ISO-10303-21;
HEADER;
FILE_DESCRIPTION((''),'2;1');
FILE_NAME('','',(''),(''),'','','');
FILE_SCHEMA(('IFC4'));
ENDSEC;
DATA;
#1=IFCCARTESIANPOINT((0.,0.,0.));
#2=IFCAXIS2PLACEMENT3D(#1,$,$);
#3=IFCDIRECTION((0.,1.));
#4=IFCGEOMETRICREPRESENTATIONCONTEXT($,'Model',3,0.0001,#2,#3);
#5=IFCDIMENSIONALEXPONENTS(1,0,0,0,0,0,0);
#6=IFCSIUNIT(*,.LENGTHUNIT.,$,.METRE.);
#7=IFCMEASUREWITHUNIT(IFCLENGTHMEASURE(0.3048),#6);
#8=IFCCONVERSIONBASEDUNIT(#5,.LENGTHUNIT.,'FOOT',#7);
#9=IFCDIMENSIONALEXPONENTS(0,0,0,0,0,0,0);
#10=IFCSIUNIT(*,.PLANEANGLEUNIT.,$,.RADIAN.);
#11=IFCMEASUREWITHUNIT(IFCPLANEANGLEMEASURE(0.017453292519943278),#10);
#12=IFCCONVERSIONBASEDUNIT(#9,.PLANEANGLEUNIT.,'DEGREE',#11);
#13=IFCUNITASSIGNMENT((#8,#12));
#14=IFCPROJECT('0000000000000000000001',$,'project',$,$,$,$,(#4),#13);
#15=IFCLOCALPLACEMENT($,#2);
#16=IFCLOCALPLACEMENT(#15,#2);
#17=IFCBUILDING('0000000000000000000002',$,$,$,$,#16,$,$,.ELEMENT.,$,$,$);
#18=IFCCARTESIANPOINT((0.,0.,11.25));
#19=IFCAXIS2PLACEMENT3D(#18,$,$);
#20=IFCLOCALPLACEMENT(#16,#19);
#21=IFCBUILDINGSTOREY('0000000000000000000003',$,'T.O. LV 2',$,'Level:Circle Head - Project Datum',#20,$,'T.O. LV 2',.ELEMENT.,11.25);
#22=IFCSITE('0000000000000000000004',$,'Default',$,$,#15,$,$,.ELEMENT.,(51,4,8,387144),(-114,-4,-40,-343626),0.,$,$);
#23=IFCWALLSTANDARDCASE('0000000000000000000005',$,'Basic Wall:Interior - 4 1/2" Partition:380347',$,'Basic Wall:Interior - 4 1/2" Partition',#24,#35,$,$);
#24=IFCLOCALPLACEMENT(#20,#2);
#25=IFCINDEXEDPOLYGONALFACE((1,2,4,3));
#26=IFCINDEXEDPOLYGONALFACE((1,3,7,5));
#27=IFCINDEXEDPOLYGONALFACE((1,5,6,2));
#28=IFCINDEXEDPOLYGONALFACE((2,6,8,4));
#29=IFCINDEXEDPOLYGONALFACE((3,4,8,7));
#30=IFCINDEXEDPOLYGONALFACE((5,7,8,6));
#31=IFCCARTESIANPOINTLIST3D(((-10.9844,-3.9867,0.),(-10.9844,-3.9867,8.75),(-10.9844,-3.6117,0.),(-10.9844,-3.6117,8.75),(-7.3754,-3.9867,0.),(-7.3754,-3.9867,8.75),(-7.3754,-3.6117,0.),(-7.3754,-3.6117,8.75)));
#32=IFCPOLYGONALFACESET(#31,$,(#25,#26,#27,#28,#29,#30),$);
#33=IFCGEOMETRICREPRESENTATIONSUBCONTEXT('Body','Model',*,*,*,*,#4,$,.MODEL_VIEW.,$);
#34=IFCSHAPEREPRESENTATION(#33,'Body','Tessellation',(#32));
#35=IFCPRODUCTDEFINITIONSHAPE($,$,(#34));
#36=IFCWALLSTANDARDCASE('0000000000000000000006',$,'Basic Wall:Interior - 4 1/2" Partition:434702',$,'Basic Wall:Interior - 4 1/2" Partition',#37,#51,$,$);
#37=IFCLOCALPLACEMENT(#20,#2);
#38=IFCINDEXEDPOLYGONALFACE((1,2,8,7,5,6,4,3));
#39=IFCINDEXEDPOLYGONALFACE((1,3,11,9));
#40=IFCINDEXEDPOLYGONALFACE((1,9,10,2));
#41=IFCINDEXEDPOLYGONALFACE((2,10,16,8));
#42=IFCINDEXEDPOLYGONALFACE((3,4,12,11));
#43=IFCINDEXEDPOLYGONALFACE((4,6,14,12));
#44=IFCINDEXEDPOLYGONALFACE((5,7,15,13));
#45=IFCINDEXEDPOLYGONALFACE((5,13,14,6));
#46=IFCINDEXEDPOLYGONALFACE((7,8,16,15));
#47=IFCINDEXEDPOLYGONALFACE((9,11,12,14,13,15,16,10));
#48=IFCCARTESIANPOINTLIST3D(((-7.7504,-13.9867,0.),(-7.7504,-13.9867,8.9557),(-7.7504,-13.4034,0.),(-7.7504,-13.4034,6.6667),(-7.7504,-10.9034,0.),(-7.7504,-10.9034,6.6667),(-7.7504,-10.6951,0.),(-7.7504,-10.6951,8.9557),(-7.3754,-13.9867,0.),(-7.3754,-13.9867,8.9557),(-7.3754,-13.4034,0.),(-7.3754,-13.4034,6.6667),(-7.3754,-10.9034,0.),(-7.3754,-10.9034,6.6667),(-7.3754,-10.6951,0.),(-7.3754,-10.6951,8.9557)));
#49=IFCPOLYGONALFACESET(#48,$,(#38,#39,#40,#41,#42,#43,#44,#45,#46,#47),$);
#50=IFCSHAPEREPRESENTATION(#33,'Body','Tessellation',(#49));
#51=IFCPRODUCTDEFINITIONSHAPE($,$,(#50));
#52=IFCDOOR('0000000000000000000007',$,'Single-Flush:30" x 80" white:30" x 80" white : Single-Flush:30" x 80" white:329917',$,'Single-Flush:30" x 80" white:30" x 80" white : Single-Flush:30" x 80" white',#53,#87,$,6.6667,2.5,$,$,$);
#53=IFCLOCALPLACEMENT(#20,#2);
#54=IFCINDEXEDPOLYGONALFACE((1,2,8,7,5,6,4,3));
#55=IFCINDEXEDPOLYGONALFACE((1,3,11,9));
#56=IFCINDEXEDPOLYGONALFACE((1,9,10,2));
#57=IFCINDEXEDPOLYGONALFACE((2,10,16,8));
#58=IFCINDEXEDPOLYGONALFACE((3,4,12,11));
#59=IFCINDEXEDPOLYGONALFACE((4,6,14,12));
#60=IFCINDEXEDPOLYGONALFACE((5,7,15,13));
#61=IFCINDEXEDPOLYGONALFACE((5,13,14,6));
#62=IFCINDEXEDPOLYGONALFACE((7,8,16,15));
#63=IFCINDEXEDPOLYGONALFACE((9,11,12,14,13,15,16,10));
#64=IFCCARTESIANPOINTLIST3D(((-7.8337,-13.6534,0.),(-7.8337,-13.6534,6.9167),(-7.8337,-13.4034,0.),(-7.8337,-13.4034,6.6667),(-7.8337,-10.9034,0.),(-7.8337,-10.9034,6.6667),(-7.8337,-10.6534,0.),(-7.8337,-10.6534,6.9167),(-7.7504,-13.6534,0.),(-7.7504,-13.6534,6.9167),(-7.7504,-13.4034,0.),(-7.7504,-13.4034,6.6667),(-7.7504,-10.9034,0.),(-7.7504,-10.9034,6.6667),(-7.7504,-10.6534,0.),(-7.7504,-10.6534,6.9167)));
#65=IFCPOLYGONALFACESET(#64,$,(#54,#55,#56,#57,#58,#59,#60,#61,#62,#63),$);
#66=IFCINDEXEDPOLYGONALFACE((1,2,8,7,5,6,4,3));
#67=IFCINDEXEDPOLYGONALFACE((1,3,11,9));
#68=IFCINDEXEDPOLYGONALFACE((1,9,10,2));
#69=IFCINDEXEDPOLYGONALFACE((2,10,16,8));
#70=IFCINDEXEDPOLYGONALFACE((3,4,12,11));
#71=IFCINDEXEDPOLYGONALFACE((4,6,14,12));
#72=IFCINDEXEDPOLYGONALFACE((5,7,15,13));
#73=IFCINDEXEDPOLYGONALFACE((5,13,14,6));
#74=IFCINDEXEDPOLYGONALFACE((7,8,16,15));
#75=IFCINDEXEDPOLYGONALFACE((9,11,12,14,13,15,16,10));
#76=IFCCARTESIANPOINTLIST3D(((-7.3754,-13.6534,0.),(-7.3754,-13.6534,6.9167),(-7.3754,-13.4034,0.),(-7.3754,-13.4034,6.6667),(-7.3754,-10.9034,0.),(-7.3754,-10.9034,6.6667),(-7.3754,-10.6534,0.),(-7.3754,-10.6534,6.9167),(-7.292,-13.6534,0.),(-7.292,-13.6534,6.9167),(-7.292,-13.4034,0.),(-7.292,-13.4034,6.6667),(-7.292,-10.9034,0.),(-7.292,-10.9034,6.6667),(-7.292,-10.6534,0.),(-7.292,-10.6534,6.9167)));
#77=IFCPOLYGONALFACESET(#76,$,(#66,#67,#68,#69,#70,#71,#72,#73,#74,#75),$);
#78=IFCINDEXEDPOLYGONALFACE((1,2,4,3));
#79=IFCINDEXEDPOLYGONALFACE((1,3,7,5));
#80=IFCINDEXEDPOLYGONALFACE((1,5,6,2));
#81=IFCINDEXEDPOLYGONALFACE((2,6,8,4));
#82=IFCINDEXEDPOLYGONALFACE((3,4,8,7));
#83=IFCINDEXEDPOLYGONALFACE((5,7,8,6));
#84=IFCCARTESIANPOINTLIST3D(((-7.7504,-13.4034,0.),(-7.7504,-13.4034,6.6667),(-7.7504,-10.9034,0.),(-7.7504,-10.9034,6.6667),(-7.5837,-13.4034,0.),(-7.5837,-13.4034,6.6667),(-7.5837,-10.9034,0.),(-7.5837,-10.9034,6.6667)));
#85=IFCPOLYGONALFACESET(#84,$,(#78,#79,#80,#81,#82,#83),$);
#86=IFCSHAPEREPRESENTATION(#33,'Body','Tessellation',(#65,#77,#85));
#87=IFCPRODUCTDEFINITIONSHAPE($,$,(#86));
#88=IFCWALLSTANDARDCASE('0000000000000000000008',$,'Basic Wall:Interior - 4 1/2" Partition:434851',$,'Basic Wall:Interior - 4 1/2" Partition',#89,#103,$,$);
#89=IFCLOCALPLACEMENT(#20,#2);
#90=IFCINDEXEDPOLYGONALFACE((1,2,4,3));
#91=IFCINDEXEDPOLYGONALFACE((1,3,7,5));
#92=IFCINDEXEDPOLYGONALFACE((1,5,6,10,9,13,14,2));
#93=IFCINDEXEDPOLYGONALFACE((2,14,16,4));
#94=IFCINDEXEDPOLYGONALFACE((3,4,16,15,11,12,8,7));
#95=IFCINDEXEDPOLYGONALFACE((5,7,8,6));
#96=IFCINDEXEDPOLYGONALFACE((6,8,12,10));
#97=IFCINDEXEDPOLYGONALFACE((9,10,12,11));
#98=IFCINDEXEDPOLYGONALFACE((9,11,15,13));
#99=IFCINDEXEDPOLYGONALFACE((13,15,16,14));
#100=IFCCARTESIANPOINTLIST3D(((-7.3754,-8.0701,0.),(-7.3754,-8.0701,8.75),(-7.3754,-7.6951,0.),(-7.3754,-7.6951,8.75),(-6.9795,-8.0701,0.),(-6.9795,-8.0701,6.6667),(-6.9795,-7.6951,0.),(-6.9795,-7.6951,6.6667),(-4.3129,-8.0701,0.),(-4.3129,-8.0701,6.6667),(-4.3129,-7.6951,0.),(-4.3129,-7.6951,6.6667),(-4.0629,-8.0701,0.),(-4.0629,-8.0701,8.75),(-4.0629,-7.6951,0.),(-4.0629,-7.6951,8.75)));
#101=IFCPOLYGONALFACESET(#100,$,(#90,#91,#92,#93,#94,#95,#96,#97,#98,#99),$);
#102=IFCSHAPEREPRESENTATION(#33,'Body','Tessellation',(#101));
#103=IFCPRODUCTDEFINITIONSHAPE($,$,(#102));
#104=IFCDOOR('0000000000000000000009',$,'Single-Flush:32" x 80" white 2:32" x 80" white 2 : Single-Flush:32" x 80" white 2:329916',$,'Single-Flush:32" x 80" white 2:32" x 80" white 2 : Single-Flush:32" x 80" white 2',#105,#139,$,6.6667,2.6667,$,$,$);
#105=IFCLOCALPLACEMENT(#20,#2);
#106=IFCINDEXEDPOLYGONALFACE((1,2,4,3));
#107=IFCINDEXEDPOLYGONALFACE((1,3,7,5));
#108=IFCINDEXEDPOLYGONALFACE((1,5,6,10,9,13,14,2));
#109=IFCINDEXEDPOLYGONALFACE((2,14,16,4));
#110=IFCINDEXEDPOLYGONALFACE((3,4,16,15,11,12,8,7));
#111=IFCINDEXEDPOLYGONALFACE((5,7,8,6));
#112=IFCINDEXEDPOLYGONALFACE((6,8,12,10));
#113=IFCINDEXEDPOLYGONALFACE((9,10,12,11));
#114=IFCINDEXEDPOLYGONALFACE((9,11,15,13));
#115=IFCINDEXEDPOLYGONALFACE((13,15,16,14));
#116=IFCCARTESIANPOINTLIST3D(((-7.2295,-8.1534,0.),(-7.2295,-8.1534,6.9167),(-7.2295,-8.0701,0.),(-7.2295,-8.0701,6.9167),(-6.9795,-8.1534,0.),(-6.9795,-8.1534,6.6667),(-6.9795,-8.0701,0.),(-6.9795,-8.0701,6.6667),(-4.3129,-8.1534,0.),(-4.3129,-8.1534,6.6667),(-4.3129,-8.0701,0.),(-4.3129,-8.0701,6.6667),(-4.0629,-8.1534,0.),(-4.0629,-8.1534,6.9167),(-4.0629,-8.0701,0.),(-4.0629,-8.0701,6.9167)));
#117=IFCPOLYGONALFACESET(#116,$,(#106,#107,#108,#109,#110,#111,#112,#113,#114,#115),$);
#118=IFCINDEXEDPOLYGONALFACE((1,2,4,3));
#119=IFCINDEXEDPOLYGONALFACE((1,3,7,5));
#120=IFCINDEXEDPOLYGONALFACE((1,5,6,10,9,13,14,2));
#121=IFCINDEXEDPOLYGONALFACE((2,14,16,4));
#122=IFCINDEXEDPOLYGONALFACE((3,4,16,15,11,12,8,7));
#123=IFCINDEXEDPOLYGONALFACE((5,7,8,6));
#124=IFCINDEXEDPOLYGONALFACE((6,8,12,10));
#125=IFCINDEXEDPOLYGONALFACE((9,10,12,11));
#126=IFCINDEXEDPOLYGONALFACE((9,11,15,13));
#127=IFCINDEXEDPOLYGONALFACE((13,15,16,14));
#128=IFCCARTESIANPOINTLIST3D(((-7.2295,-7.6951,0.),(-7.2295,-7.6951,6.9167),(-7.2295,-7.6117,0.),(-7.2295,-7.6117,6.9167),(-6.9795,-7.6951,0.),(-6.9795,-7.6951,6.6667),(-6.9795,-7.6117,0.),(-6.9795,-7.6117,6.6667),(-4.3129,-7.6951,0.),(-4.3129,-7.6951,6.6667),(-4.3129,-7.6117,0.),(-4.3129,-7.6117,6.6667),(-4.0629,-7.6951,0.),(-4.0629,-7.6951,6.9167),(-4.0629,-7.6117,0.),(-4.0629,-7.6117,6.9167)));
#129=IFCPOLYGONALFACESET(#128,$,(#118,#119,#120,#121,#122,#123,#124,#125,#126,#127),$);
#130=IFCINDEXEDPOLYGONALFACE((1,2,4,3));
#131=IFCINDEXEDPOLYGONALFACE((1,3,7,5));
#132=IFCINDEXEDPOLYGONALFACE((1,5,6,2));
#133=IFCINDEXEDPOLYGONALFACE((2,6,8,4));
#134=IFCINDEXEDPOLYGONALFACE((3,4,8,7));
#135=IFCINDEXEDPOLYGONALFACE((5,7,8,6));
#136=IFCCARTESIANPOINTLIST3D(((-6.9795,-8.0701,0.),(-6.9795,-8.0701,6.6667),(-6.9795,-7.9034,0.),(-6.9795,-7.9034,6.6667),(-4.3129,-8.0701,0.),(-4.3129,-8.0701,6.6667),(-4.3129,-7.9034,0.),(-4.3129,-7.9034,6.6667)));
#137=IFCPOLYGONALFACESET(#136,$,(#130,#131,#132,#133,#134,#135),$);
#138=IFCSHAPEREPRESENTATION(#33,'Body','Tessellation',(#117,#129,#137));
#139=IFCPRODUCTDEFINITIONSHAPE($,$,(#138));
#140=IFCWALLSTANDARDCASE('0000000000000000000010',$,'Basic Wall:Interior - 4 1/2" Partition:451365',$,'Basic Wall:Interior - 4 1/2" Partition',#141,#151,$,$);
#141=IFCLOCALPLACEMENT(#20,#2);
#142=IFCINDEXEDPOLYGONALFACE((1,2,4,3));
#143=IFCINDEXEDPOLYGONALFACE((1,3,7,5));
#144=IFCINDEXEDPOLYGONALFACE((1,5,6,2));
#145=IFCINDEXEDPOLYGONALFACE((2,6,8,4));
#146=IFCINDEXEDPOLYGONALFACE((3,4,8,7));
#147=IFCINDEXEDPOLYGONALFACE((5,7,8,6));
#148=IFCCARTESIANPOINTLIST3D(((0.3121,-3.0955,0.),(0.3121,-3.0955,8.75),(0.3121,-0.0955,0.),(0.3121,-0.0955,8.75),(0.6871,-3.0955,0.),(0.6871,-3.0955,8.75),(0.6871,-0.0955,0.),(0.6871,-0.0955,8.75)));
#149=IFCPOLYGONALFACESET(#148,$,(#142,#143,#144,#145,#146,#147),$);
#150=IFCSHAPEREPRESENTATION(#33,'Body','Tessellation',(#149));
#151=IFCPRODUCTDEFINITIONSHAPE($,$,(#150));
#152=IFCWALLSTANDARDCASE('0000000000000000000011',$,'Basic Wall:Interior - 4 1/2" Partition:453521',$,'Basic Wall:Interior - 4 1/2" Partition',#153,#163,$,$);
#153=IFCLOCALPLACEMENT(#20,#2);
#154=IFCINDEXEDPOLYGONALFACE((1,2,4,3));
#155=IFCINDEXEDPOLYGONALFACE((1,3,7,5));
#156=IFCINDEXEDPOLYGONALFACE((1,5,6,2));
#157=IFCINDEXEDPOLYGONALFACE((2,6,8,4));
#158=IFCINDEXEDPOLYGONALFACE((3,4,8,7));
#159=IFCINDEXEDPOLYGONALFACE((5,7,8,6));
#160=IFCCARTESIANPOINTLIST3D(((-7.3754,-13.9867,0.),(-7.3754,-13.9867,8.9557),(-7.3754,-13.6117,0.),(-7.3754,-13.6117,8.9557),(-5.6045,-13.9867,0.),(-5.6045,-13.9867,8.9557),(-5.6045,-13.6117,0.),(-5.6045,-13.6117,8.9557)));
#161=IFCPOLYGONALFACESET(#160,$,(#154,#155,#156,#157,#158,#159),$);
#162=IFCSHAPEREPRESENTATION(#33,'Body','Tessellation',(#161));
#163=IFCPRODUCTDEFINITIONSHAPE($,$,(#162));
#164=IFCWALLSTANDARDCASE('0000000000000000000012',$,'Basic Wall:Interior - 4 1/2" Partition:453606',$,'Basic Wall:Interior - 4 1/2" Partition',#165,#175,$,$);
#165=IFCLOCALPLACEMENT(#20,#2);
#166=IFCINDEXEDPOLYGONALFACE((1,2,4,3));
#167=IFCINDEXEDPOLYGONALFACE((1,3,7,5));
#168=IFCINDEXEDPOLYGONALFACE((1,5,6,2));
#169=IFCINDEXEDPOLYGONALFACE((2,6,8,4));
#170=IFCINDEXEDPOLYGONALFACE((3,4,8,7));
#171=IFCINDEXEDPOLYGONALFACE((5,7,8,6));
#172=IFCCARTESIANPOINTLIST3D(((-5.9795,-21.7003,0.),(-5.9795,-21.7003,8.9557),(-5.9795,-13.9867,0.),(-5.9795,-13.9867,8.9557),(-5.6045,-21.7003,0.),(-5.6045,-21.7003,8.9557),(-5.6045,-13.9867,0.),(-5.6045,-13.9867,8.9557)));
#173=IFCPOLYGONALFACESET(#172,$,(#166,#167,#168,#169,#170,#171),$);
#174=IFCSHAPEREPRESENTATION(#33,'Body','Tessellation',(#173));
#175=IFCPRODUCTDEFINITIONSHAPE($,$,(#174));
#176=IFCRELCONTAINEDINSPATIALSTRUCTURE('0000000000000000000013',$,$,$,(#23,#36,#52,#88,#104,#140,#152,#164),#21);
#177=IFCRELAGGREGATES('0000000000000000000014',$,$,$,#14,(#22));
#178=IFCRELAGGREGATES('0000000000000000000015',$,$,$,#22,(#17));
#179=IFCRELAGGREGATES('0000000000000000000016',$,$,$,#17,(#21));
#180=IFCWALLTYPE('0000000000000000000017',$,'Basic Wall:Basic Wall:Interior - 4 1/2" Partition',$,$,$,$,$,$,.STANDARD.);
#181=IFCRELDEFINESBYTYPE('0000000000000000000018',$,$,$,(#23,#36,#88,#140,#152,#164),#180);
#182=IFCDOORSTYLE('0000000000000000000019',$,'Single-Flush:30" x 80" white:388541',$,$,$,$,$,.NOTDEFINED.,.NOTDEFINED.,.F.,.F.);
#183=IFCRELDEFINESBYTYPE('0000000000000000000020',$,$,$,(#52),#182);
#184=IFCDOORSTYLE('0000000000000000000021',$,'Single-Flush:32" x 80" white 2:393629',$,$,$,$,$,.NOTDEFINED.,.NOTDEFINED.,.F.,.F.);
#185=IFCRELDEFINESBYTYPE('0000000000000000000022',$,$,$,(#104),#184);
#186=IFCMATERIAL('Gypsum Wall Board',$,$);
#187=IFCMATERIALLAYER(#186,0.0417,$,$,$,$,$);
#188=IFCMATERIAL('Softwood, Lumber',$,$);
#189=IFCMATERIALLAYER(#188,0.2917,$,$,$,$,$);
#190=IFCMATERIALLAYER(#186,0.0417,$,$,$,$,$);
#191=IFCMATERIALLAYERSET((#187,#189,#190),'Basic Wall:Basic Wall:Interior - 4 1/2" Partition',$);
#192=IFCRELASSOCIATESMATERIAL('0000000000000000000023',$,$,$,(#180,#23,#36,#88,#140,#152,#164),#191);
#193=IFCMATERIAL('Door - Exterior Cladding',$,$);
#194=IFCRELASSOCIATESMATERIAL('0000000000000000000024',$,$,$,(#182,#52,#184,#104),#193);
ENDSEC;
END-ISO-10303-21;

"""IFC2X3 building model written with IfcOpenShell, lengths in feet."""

from ifc_helpers import new_model, entity, si_unit, converted_unit, direction, frame, frame_2d, origin, place, context, subcontext, project, spatial, polyline, rectangle, outline, extrude, source, transform, mapped, material, layer, layer_set, layer_usage, type_object, type_shapes, element, fill, save


model = new_model("IFC2X3")

# Units and contexts
model_context = context("Model", 3, precision=0.0001, world=origin(), true_north=direction((0.0, 1.0)))
body_context = subcontext(model_context, "Body", "Model", "MODEL_VIEW")
ifc_project = project(units=[converted_unit("LENGTHUNIT", "FOOT", entity("IfcLengthMeasure", 0.3048), si_unit("LENGTHUNIT", "METRE"), dimensions=[1, 0, 0, 0, 0, 0, 0]), converted_unit("PLANEANGLEUNIT", "DEGREE", entity("IfcPlaneAngleMeasure", 0.017453292519943278), si_unit("PLANEANGLEUNIT", "RADIAN"), dimensions=[0, 0, 0, 0, 0, 0, 0])], contexts=[model_context])

# Site, building, storey
site_placement = place(None, origin())
site = spatial("IfcSite", under=ifc_project, at=site_placement, Name="Default", CompositionType="ELEMENT", RefLatitude=(51, 4, 8, 387144), RefLongitude=(-114, -4, -40, -343626), RefElevation=0.0)
building_placement = place(site_placement, origin())
building = spatial("IfcBuilding", under=site, at=building_placement, CompositionType="ELEMENT")
storey_placement = place(building_placement, frame((0.0, 0.0, 11.25)))
storey = spatial("IfcBuildingStorey", under=building, at=storey_placement, Name="T.O. LV 2", ObjectType="Level:Circle Head - Project Datum", LongName="T.O. LV 2", CompositionType="ELEMENT", Elevation=11.25)

# Shared definitions
ifc_material_1 = material(Name="Gypsum Wall Board")

# Wall
ifc_layer_1 = layer(ifc_material_1, 0.0417)
ifc_material_2 = material(Name="Softwood, Lumber")
ifc_layer_2 = layer(ifc_material_2, 0.2917)
ifc_layer_3 = layer(ifc_material_1, 0.0417)
ifc_layer_set_1 = layer_set([ifc_layer_1, ifc_layer_2, ifc_layer_3], Name="Basic Wall:Basic Wall:Interior - 4 1/2\" Partition")
ifc_layer_usage_1 = layer_usage(ifc_layer_set_1, "AXIS2", "NEGATIVE", 0.1875)
wall_type_1 = type_object("IfcWallType", Name="Basic Wall:Basic Wall:Interior - 4 1/2\" Partition", PredefinedType="STANDARD", material=ifc_layer_set_1)
wall_1_placement = place(storey_placement, frame((-10.9844, -3.7992, 0.0)))
element("IfcWallStandardCase", 1, at=wall_1_placement, inside=storey, type_object=wall_type_1, material=ifc_layer_usage_1, Name="Basic Wall:Interior - 4 1/2\" Partition:380347", ObjectType="Basic Wall:Interior - 4 1/2\" Partition", context=body_context, shape_type="SweptSolid", body=[
    extrude(rectangle(XDim=3.609, YDim=0.375, at=frame_2d((1.8045, 0.0), x_axis=(-1.0, 0.0))), origin(), (0.0, 0.0, 1.0), 8.75),
])

# Walls, openings, doors
ifc_layer_usage_2 = layer_usage(ifc_layer_set_1, "AXIS2", "NEGATIVE", 0.1875)
wall_2_placement = place(storey_placement, frame((-7.5629, -10.6951, 0.0), z_axis=(0.0, 0.0, 1.0), x_axis=(0.0, -1.0, 0.0)))
wall_2 = element("IfcWallStandardCase", 2, at=wall_2_placement, inside=storey, type_object=wall_type_1, material=ifc_layer_usage_2, Name="Basic Wall:Interior - 4 1/2\" Partition:434702", ObjectType="Basic Wall:Interior - 4 1/2\" Partition", context=body_context, shape_type="SweptSolid", body=[
    extrude(rectangle(XDim=3.2917, YDim=0.375, at=frame_2d((1.6458, 0.0), x_axis=(1.0, 0.0))), origin(), (0.0, 0.0, 1.0), 8.9557),
])
opening_1_placement = place(wall_2_placement, frame((-10.6951, 7.5629, 0.0), z_axis=(0.0, 0.0, 1.0), x_axis=(0.0, 1.0, 0.0)))
opening_1 = element("IfcOpeningElement", 3, at=opening_1_placement, cuts=wall_2, ObjectType="Opening", context=body_context, shape_type="SweptSolid", body=[
    extrude(rectangle(XDim=6.6667, YDim=2.5, at=frame_2d((0.0, 0.0), x_axis=(0.0, 1.0))), frame((-7.7541, -12.1534, 3.3333), z_axis=(1.0, 0.0, 0.0), x_axis=(0.0, -1.0, 0.0)), (0.0, 0.0, 1.0), 0.3825),
])
ifc_material_3 = material(Name="Door - Exterior Cladding")
door_style_1 = type_object("IfcDoorStyle", Name="Single-Flush:30\" x 80\" white:388541", ConstructionType="NOTDEFINED", OperationType="NOTDEFINED", ParameterTakesPrecedence=False, Sizeable=False, material=ifc_material_3)
shared_shape_1 = source(origin(), body_context, "Body", "SweptSolid", [
    extrude(outline(polyline([(-3.5208, -1.5), (3.3958, -1.5), (3.3958, -1.25), (-3.2708, -1.25), (-3.2708, 1.25), (3.3958, 1.25), (3.3958, 1.5), (-3.5208, 1.5), (-3.5208, -1.5)])), frame((1.25, 0.3788, 3.3958), z_axis=(0.0, 1.0, 0.0), x_axis=(0.0, 0.0, -1.0)), (0.0, 0.0, 1.0), 0.0833),
    extrude(outline(polyline([(-1.5, -3.3958), (-1.25, -3.3958), (-1.25, 3.2708), (1.25, 3.2708), (1.25, -3.3958), (1.5, -3.3958), (1.5, 3.5208), (-1.5, 3.5208), (-1.5, -3.3958)])), frame((1.25, -0.0796, 3.3958), z_axis=(0.0, 1.0, 0.0), x_axis=(-1.0, 0.0, 0.0)), (0.0, 0.0, 1.0), 0.0833),
    extrude(rectangle(XDim=2.5, YDim=0.1667, at=frame_2d((0.0, 0.0), x_axis=(1.0, 0.0))), frame((1.25, 0.2954, 0.0), z_axis=(0.0, 0.0, 1.0), x_axis=(-1.0, 0.0, 0.0)), (0.0, 0.0, 1.0), 6.6667),
])
type_shapes(door_style_1, [shared_shape_1])
door_1_placement = place(opening_1_placement, frame((-7.3716, -13.4034, 0.0), z_axis=(0.0, 0.0, 1.0), x_axis=(0.0, 1.0, 0.0)))
door_1 = element("IfcDoor", 4, at=door_1_placement, inside=storey, type_object=door_style_1, material=ifc_material_3, Name="Single-Flush:30\" x 80\" white:30\" x 80\" white : Single-Flush:30\" x 80\" white:329917", ObjectType="Single-Flush:30\" x 80\" white:30\" x 80\" white : Single-Flush:30\" x 80\" white", OverallHeight=6.6667, OverallWidth=2.5, context=body_context, shape_type="MappedRepresentation", body=[
    mapped(shared_shape_1, transform((0.0, 0.0, 0.0), scale=1.0)),
])
fill(opening_1, door_1)
ifc_layer_usage_3 = layer_usage(ifc_layer_set_1, "AXIS2", "NEGATIVE", 0.1875)
wall_3_placement = place(storey_placement, frame((-7.3754, -7.8826, 0.0)))
wall_3 = element("IfcWallStandardCase", 5, at=wall_3_placement, inside=storey, type_object=wall_type_1, material=ifc_layer_usage_3, Name="Basic Wall:Interior - 4 1/2\" Partition:434851", ObjectType="Basic Wall:Interior - 4 1/2\" Partition", context=body_context, shape_type="SweptSolid", body=[
    extrude(rectangle(XDim=3.3125, YDim=0.375, at=frame_2d((1.6563, 0.0), x_axis=(1.0, 0.0))), origin(), (0.0, 0.0, 1.0), 8.75),
])
opening_2_placement = place(wall_3_placement, frame((7.3754, 7.8826, 0.0)))
opening_2 = element("IfcOpeningElement", 6, at=opening_2_placement, cuts=wall_3, ObjectType="Opening", context=body_context, shape_type="SweptSolid", body=[
    extrude(rectangle(XDim=6.6667, YDim=2.6667, at=frame_2d((0.0, 0.0), x_axis=(0.0, 1.0))), frame((-5.6462, -8.0738, 3.3333), z_axis=(0.0, 1.0, 0.0), x_axis=(1.0, 0.0, 0.0)), (0.0, 0.0, 1.0), 0.3825),
])
door_style_2 = type_object("IfcDoorStyle", Name="Single-Flush:32\" x 80\" white 2:393629", ConstructionType="NOTDEFINED", OperationType="NOTDEFINED", ParameterTakesPrecedence=False, Sizeable=False, material=ifc_material_3)
shared_shape_2 = source(origin(), body_context, "Body", "SweptSolid", [
    extrude(outline(polyline([(-3.5208, -1.5833), (3.3958, -1.5833), (3.3958, -1.3333), (-3.2708, -1.3333), (-3.2708, 1.3333), (3.3958, 1.3333), (3.3958, 1.5833), (-3.5208, 1.5833), (-3.5208, -1.5833)])), frame((1.3333, 0.3788, 3.3958), z_axis=(0.0, 1.0, 0.0), x_axis=(0.0, 0.0, -1.0)), (0.0, 0.0, 1.0), 0.0833),
    extrude(outline(polyline([(-1.5833, -3.3958), (-1.3333, -3.3958), (-1.3333, 3.2708), (1.3333, 3.2708), (1.3333, -3.3958), (1.5833, -3.3958), (1.5833, 3.5208), (-1.5833, 3.5208), (-1.5833, -3.3958)])), frame((1.3333, -0.0796, 3.3958), z_axis=(0.0, 1.0, 0.0), x_axis=(-1.0, 0.0, 0.0)), (0.0, 0.0, 1.0), 0.0833),
    extrude(rectangle(XDim=2.6667, YDim=0.1667, at=frame_2d((0.0, 0.0), x_axis=(1.0, 0.0))), frame((1.3333, 0.2954, 0.0), z_axis=(0.0, 0.0, 1.0), x_axis=(-1.0, 0.0, 0.0)), (0.0, 0.0, 1.0), 6.6667),
])
type_shapes(door_style_2, [shared_shape_2])
door_2_placement = place(opening_2_placement, frame((-4.3129, -7.6913, 0.0), z_axis=(0.0, 0.0, 1.0), x_axis=(-1.0, 0.0, 0.0)))
door_2 = element("IfcDoor", 7, at=door_2_placement, inside=storey, type_object=door_style_2, material=ifc_material_3, Name="Single-Flush:32\" x 80\" white 2:32\" x 80\" white 2 : Single-Flush:32\" x 80\" white 2:329916", ObjectType="Single-Flush:32\" x 80\" white 2:32\" x 80\" white 2 : Single-Flush:32\" x 80\" white 2", OverallHeight=6.6667, OverallWidth=2.6667, context=body_context, shape_type="MappedRepresentation", body=[
    mapped(shared_shape_2, transform((0.0, 0.0, 0.0), scale=1.0)),
])
fill(opening_2, door_2)

# Walls
ifc_layer_usage_4 = layer_usage(ifc_layer_set_1, "AXIS2", "NEGATIVE", 0.1875)
wall_4_placement = place(storey_placement, frame((0.4996, -0.0955, 0.0), z_axis=(0.0, 0.0, 1.0), x_axis=(0.0, -1.0, 0.0)))
element("IfcWallStandardCase", 8, at=wall_4_placement, inside=storey, type_object=wall_type_1, material=ifc_layer_usage_4, Name="Basic Wall:Interior - 4 1/2\" Partition:451365", ObjectType="Basic Wall:Interior - 4 1/2\" Partition", context=body_context, shape_type="SweptSolid", body=[
    extrude(rectangle(XDim=3.0, YDim=0.375, at=frame_2d((1.5, 0.0), x_axis=(-1.0, 0.0))), origin(), (0.0, 0.0, 1.0), 8.75),
])
ifc_layer_usage_5 = layer_usage(ifc_layer_set_1, "AXIS2", "NEGATIVE", 0.1875)
wall_5_placement = place(storey_placement, frame((-7.3754, -13.7992, 0.0)))
element("IfcWallStandardCase", 9, at=wall_5_placement, inside=storey, type_object=wall_type_1, material=ifc_layer_usage_5, Name="Basic Wall:Interior - 4 1/2\" Partition:453521", ObjectType="Basic Wall:Interior - 4 1/2\" Partition", context=body_context, shape_type="SweptSolid", body=[
    extrude(rectangle(XDim=1.7708, YDim=0.375, at=frame_2d((0.8854, 0.0), x_axis=(-1.0, 0.0))), origin(), (0.0, 0.0, 1.0), 8.9557),
])
ifc_layer_usage_6 = layer_usage(ifc_layer_set_1, "AXIS2", "NEGATIVE", 0.1875)
wall_6_placement = place(storey_placement, frame((-5.792, -13.9867, 0.0), z_axis=(0.0, 0.0, 1.0), x_axis=(0.0, -1.0, 0.0)))
element("IfcWallStandardCase", 10, at=wall_6_placement, inside=storey, type_object=wall_type_1, material=ifc_layer_usage_6, Name="Basic Wall:Interior - 4 1/2\" Partition:453606", ObjectType="Basic Wall:Interior - 4 1/2\" Partition", context=body_context, shape_type="SweptSolid", body=[
    extrude(rectangle(XDim=7.7135, YDim=0.375, at=frame_2d((3.8568, 0.0), x_axis=(-1.0, 0.0))), origin(), (0.0, 0.0, 1.0), 8.9557),
])

save(model, "model.ifc")
